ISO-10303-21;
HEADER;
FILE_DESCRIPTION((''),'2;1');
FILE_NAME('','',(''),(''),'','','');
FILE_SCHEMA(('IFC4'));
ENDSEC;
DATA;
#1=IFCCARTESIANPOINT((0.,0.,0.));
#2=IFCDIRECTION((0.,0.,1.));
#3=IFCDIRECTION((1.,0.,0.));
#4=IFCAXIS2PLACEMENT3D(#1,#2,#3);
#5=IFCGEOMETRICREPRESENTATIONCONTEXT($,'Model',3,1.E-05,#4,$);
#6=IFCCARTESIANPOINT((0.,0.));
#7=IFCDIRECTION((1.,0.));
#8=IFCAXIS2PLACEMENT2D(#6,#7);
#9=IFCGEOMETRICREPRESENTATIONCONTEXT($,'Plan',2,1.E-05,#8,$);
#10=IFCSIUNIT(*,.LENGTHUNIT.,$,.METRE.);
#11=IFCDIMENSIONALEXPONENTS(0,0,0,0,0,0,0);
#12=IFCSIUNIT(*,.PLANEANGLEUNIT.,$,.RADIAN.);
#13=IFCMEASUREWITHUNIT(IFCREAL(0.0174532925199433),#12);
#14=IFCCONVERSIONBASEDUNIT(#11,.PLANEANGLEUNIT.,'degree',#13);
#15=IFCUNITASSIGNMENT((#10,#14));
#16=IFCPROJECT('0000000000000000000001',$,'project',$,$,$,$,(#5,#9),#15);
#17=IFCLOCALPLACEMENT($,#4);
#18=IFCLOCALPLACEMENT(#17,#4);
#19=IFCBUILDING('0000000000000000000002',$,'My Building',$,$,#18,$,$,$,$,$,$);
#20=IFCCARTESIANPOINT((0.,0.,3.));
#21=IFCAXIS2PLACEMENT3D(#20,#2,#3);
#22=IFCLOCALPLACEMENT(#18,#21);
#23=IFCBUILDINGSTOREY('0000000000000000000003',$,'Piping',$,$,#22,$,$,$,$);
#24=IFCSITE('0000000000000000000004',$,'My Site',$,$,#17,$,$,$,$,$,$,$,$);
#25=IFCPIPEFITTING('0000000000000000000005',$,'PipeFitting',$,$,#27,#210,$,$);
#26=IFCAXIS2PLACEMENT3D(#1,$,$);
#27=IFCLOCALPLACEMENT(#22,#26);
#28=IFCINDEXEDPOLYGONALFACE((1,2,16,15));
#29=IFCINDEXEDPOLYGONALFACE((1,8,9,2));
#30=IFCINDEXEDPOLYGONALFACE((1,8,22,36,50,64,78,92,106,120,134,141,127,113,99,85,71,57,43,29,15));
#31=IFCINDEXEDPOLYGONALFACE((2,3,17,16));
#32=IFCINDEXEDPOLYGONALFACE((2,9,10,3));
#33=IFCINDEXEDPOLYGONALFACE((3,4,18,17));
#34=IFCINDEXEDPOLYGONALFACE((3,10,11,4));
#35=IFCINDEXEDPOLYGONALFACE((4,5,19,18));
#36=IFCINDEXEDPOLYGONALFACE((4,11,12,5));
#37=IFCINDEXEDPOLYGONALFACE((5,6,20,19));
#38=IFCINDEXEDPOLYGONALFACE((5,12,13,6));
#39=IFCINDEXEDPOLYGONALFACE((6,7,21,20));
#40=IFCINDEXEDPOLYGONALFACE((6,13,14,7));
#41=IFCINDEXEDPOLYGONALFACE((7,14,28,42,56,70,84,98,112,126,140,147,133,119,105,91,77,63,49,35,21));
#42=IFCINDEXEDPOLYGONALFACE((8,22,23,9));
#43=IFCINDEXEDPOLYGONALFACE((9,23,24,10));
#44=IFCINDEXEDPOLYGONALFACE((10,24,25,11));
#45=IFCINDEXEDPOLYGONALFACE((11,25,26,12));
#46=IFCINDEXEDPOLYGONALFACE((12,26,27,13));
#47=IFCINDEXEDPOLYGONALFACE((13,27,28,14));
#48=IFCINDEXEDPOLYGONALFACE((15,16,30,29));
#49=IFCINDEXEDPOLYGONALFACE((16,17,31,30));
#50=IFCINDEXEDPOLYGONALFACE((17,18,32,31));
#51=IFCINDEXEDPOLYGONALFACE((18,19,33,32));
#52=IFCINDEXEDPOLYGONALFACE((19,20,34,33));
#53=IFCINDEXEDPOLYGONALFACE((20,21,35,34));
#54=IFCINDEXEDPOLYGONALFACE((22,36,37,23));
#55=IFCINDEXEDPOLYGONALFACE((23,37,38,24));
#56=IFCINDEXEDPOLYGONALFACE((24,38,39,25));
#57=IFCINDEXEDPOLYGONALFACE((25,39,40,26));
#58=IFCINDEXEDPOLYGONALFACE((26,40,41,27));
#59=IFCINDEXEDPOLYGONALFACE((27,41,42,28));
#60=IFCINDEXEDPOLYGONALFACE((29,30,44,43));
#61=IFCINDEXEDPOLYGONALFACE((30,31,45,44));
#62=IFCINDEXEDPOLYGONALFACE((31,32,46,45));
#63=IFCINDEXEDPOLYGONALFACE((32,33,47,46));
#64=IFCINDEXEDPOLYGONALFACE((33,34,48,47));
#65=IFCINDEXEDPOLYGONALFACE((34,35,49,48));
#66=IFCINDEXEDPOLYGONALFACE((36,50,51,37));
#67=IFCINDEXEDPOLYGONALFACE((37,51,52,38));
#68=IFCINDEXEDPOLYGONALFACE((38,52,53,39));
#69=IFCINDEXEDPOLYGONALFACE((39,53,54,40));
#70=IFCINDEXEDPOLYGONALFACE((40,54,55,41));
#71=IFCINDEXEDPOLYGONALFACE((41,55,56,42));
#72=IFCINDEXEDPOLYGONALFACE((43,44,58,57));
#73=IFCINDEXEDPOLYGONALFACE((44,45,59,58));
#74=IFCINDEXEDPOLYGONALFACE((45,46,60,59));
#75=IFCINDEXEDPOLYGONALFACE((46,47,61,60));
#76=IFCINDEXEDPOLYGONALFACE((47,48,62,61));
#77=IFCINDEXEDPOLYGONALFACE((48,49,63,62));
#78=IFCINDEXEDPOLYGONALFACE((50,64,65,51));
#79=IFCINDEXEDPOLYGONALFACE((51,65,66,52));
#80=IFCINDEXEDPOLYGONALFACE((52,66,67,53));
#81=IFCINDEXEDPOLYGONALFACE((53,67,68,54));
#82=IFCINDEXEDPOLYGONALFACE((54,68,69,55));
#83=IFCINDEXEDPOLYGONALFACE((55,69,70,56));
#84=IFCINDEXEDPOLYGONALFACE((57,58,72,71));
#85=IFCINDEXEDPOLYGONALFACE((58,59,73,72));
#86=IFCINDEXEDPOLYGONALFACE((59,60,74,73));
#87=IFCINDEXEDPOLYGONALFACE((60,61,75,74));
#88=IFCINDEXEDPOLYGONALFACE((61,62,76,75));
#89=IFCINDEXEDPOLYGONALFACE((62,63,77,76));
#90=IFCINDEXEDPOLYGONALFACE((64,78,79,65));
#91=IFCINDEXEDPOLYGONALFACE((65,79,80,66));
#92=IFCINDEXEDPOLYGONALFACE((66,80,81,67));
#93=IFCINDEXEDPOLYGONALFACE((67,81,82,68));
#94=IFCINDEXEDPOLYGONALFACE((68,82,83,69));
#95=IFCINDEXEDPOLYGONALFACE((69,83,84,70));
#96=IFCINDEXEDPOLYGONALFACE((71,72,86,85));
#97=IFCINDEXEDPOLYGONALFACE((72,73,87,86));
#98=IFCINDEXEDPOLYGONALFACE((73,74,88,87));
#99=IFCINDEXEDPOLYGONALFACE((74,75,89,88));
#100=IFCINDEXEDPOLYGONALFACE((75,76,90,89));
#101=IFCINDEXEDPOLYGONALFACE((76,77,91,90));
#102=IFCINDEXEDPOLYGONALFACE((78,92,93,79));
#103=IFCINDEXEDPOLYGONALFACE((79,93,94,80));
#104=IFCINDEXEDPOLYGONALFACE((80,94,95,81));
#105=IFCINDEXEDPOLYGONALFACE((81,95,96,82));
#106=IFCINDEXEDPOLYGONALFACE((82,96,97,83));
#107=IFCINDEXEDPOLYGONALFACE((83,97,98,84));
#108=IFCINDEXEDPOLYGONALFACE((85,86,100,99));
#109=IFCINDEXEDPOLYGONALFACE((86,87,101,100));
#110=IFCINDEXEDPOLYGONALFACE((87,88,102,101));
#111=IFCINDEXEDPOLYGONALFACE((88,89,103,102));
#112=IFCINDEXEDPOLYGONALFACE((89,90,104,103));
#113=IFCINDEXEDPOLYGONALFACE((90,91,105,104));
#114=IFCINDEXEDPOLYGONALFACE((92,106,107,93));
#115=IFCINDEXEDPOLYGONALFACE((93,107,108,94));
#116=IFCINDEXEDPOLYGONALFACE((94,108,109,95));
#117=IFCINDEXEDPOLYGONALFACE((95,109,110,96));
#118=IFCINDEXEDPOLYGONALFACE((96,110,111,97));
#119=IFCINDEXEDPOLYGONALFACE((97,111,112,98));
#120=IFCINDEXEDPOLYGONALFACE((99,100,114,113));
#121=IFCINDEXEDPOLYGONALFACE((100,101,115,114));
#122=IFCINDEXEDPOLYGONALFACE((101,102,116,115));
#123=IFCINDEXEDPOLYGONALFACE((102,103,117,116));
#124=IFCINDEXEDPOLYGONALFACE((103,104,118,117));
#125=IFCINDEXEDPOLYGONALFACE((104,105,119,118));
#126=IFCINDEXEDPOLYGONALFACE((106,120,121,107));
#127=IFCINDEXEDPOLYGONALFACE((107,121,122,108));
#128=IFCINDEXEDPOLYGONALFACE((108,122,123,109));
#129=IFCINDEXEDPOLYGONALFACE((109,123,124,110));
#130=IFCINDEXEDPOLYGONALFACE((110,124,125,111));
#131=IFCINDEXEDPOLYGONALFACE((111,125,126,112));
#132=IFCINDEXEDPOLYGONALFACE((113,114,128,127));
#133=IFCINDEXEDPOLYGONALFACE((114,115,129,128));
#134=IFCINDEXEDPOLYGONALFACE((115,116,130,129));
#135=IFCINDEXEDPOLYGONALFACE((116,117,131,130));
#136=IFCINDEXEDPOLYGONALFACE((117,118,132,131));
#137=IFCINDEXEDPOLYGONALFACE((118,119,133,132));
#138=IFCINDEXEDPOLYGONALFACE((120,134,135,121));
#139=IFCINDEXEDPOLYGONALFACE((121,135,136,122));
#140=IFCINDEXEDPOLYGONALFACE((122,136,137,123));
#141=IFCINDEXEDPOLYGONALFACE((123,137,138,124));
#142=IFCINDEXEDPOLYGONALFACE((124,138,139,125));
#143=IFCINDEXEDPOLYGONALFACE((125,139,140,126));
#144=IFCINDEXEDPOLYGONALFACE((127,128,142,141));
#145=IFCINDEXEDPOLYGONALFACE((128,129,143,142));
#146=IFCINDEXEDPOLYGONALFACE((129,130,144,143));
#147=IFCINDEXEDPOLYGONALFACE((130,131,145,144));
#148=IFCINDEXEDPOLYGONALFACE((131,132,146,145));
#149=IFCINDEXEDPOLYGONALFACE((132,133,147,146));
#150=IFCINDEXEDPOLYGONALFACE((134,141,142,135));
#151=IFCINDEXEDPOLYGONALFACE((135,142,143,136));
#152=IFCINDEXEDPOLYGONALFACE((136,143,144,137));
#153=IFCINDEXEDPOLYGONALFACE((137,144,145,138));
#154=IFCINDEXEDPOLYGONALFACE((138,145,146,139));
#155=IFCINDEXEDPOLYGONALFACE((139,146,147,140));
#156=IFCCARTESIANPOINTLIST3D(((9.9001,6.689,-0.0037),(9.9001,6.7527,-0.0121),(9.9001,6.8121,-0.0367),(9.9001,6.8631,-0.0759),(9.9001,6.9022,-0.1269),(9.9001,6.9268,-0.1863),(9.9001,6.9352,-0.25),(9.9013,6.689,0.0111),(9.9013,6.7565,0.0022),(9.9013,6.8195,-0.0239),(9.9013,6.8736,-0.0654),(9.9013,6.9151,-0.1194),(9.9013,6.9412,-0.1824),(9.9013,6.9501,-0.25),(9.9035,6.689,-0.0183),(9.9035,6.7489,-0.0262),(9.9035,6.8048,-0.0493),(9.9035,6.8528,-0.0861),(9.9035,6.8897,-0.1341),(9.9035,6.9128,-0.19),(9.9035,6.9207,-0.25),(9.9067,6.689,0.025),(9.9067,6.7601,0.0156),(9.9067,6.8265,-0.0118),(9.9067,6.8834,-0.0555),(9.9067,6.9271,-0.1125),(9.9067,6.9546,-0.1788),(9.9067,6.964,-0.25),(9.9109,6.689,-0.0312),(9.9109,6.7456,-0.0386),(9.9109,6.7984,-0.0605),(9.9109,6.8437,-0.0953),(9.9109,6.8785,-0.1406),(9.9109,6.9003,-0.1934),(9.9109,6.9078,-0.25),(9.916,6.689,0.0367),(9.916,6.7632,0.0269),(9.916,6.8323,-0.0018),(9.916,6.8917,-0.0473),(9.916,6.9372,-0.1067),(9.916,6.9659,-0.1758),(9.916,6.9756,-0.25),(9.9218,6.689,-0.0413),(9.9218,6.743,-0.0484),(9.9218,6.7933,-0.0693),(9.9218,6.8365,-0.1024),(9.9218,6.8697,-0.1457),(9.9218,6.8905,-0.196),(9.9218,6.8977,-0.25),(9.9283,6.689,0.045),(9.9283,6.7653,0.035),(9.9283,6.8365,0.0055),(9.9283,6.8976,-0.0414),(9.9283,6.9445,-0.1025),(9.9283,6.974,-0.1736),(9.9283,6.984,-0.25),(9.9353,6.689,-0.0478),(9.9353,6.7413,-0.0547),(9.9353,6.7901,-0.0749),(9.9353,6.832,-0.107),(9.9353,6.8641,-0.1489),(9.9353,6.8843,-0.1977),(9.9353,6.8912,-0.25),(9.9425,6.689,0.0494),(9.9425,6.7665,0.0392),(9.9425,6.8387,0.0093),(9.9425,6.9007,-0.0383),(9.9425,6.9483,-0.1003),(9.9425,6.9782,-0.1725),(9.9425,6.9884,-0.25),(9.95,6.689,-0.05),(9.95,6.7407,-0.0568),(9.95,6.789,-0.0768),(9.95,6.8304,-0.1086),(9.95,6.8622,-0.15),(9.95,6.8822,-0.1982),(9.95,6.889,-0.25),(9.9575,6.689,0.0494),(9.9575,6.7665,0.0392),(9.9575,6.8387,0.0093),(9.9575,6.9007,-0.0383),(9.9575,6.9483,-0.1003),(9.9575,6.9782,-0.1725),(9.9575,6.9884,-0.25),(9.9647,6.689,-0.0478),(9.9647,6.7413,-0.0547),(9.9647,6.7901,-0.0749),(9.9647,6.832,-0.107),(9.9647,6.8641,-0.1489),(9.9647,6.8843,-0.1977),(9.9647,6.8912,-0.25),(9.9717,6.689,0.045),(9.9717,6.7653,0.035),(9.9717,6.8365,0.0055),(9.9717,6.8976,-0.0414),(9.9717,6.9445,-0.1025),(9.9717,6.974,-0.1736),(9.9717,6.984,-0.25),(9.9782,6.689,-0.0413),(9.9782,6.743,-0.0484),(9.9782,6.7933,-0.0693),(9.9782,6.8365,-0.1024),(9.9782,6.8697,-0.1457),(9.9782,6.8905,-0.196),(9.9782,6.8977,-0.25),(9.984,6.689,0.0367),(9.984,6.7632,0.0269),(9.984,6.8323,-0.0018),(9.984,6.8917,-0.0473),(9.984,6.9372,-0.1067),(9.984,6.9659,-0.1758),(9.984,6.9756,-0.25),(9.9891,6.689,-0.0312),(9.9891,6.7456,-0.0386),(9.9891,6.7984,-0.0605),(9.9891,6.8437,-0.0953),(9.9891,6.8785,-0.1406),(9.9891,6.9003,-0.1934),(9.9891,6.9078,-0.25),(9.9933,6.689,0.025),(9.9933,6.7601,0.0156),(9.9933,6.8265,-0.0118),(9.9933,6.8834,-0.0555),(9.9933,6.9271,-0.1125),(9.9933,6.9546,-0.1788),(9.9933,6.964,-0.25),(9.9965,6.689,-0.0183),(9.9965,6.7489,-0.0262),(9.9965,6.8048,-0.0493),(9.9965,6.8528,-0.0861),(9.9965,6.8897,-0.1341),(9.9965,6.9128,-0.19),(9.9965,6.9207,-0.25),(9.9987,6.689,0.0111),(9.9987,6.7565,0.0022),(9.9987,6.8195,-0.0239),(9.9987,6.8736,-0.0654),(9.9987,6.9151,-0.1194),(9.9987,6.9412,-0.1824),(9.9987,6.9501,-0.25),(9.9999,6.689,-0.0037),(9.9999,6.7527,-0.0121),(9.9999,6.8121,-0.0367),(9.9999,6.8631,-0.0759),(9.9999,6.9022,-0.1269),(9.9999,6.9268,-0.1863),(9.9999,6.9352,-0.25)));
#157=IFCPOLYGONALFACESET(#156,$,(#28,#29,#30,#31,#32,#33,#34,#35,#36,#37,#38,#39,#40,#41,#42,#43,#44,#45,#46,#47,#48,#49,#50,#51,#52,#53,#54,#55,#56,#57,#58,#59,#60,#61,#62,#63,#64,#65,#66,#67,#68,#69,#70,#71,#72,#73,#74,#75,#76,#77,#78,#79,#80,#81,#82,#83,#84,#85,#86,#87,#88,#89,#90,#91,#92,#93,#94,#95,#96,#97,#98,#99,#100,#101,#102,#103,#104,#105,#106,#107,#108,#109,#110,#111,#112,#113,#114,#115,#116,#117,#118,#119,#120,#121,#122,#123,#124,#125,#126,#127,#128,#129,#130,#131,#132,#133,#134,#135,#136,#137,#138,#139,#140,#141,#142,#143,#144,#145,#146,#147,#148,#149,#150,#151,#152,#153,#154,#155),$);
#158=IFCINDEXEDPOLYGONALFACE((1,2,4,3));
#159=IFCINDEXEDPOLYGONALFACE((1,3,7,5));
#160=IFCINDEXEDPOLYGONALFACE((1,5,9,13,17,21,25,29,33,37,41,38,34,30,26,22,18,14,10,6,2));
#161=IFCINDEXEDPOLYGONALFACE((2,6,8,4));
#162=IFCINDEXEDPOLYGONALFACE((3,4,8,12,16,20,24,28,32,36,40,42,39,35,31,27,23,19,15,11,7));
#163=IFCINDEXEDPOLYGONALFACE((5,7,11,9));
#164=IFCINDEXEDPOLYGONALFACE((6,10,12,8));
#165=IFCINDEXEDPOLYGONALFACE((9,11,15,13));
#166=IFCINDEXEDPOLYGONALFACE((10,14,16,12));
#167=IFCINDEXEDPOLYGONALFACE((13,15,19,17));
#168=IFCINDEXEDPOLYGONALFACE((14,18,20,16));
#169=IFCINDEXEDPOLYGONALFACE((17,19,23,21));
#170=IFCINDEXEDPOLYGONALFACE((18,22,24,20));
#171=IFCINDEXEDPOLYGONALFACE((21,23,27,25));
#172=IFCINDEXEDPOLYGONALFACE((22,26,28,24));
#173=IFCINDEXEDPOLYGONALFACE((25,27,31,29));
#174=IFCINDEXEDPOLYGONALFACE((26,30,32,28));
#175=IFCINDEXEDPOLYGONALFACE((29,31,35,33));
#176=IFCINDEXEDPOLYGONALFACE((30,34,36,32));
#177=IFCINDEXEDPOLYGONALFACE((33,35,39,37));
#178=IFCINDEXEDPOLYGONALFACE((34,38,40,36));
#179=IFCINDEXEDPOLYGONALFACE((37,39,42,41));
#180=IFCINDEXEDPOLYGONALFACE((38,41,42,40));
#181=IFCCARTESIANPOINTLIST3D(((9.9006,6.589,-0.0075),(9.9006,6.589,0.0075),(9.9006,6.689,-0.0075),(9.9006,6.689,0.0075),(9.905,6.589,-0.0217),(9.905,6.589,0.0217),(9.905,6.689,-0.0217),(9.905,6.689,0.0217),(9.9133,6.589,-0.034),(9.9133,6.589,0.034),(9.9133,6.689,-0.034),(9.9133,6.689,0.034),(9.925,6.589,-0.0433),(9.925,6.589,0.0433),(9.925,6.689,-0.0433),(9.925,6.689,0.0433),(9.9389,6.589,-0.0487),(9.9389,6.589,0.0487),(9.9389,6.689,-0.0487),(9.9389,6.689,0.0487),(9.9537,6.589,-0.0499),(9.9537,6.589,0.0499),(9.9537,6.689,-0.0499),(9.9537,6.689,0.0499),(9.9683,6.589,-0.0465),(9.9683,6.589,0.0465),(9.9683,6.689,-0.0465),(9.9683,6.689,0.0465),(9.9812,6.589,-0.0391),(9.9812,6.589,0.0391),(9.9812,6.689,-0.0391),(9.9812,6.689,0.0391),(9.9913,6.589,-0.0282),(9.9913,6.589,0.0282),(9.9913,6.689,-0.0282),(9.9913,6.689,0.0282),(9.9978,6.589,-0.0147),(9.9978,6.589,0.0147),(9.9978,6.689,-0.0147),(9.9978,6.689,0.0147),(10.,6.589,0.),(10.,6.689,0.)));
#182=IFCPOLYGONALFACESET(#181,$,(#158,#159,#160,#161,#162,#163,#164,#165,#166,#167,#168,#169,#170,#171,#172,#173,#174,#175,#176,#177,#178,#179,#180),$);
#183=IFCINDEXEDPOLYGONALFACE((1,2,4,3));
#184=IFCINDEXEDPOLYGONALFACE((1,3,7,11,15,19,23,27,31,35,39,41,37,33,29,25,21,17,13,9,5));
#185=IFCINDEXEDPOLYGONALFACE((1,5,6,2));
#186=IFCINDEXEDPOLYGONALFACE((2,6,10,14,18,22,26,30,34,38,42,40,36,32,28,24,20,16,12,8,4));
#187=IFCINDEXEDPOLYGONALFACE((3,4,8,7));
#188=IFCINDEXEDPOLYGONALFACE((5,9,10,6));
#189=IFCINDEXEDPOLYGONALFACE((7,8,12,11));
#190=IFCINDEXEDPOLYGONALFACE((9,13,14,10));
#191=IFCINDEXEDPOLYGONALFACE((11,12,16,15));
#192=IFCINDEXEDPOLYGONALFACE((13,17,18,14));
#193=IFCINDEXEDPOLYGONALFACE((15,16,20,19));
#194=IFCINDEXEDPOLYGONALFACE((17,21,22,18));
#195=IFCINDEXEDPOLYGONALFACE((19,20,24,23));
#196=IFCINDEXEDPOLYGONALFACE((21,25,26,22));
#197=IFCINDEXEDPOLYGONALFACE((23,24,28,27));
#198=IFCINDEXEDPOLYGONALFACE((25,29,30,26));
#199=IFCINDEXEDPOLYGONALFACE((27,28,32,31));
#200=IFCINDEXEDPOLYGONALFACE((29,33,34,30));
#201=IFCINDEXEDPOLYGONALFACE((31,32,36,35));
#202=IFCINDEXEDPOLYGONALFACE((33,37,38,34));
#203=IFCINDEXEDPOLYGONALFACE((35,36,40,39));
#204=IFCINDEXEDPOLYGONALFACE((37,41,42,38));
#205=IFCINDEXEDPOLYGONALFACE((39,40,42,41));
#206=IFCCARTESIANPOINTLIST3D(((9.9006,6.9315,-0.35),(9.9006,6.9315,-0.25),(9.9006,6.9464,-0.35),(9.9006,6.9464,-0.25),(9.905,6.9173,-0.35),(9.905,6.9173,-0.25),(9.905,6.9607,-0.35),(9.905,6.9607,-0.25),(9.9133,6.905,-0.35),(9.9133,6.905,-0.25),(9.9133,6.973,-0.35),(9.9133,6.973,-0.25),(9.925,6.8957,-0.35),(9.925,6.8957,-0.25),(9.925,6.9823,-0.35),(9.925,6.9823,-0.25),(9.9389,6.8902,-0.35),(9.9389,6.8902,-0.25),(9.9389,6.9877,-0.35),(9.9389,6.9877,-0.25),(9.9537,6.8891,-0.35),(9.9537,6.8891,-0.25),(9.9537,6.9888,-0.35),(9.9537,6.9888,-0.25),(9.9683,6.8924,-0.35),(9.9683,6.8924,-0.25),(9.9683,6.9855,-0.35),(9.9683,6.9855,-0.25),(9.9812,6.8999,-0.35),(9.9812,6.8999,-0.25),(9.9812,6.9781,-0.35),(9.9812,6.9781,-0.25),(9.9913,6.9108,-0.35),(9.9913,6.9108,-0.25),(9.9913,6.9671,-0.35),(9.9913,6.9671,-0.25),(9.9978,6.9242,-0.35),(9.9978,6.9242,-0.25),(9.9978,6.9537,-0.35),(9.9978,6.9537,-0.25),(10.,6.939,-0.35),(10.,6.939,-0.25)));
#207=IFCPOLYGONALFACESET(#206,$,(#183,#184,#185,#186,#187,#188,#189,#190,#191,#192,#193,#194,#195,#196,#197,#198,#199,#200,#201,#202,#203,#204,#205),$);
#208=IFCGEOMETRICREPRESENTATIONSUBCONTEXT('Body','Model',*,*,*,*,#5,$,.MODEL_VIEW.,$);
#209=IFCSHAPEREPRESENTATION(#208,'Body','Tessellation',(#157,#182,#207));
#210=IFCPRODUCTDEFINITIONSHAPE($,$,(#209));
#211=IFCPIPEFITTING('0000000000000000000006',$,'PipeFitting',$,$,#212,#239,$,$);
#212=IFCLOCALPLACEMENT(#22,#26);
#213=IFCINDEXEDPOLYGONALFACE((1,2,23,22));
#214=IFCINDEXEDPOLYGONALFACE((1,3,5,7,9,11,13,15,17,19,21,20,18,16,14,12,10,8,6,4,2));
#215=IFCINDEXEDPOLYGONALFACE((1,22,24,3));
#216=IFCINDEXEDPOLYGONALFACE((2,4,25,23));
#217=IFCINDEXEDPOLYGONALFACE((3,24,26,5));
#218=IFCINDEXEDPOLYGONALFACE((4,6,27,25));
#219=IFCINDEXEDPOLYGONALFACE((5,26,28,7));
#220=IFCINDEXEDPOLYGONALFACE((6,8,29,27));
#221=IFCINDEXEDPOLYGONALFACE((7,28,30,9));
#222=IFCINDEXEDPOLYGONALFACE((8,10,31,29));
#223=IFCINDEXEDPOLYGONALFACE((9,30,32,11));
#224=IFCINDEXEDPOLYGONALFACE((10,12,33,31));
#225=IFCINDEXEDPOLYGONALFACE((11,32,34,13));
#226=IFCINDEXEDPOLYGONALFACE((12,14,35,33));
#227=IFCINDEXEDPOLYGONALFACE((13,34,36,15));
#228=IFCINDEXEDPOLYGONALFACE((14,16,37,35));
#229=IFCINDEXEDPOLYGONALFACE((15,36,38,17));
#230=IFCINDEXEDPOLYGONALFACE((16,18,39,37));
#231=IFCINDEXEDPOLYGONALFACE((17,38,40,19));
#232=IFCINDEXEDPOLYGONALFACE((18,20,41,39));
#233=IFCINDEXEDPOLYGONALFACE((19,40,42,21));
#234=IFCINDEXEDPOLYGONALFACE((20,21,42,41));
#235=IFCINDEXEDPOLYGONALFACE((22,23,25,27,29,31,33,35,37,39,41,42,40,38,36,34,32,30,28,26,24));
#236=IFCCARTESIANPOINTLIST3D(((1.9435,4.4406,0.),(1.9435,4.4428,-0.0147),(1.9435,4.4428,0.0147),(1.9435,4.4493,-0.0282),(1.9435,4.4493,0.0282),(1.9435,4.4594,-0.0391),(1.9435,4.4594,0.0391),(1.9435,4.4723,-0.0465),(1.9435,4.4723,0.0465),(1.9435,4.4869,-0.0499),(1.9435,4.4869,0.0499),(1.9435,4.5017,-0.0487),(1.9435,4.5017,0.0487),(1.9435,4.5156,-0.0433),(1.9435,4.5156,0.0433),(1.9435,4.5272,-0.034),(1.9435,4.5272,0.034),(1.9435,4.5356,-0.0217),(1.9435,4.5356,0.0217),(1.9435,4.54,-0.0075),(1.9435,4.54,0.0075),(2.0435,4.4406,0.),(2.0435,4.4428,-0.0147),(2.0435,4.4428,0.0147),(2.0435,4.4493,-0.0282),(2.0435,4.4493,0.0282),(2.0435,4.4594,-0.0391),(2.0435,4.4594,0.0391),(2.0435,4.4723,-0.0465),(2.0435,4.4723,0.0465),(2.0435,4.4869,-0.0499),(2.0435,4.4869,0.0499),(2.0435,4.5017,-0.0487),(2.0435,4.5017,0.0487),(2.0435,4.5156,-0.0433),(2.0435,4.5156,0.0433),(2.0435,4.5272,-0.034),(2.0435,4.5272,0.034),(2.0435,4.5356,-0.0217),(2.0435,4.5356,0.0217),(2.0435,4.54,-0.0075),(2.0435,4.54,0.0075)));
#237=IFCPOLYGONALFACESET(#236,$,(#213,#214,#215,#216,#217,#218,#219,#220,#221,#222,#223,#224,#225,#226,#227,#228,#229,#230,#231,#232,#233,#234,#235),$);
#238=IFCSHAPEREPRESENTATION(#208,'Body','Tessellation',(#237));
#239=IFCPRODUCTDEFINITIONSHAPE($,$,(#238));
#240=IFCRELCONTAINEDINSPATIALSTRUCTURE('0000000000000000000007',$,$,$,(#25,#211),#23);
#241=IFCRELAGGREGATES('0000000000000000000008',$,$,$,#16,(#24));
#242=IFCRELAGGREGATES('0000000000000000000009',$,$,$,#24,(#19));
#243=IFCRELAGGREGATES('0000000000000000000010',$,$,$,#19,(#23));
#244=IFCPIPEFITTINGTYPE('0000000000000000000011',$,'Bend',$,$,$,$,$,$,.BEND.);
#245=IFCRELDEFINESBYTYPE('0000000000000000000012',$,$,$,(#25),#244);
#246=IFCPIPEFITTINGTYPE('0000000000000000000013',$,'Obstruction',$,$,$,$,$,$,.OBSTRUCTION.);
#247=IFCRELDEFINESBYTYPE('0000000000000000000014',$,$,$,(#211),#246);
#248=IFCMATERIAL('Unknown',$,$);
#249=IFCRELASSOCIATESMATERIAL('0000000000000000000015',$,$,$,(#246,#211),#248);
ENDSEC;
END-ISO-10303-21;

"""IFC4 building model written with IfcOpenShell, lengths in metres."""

from ifc_helpers import new_model, entity, si_unit, converted_unit, frame, origin_with_axes, origin_2d_with_axis, place, context, subcontext, project, spatial, circle, extrude, source, transform, mapped, material, material_profile, profile_set, profile_usage, type_object, type_shapes, element, save


model = new_model("IFC4")

# Units and contexts
model_context = context("Model", 3, precision=1e-05, world=origin_with_axes())
plan_context = context("Plan", 2, precision=1e-05, world=origin_2d_with_axis())
body_context = subcontext(model_context, "Body", "Model", "MODEL_VIEW")
ifc_project = project(units=[si_unit("LENGTHUNIT", "METRE"), converted_unit("PLANEANGLEUNIT", "degree", entity("IfcReal", 0.0174532925199433), si_unit("PLANEANGLEUNIT", "RADIAN"), dimensions=[0, 0, 0, 0, 0, 0, 0])], contexts=[model_context, plan_context])

# Site, building, storey
site_placement = place(None, origin_with_axes())
site = spatial("IfcSite", under=ifc_project, at=site_placement, Name="My Site")
building_placement = place(site_placement, origin_with_axes())
building = spatial("IfcBuilding", under=site, at=building_placement, Name="My Building")
storey_placement = place(building_placement, frame((0.0, 0.0, 3.0), z_axis=(0.0, 0.0, 1.0), x_axis=(1.0, 0.0, 0.0)))
storey = spatial("IfcBuildingStorey", under=building, at=storey_placement, Name="Piping")

# Shared definitions
ifc_material = material(Name="Unknown")

# Pipe fittings
pipe_fitting_type_1 = type_object("IfcPipeFittingType", Name="Bend", PredefinedType="BEND")
shared_shape = source(origin_with_axes(), body_context, "Body", "SolidModel", [
    entity("IfcSweptDiskSolid", entity("IfcIndexedPolyCurve", entity("IfcCartesianPointList3D", [[0.0, 0.0, -0.1], [0.0, -0.0732, -0.2768], [0.0, -0.25, -0.35]]), [entity("IfcArcIndex", [1, 2, 3])]), 0.05),
    extrude(circle(Radius=0.05), origin_with_axes(), (0.0, 0.0, -1.0), 0.1),
    extrude(circle(Radius=0.05), frame((0.0, -0.25, -0.35), z_axis=(0.0, -1.0, 0.0), x_axis=(1.0, 0.0, 0.0)), (0.0, 0.0, 1.0), 0.1),
])
type_shapes(pipe_fitting_type_1, [shared_shape])
for number, where, z_axis, x_axis, name in (
    (1, (9.95, 6.589, 0.0), (0.0, -1.0, 0.0), (1.0, 0.0, 0.0), "PipeFitting"),
):
    element("IfcPipeFitting", number, at=place(storey_placement, frame(where, z_axis=z_axis, x_axis=x_axis)), inside=storey, type_object=pipe_fitting_type_1, Name=name, context=body_context, shape_type="MappedRepresentation", body=[
        mapped(shared_shape, transform((0.0, 0.0, 0.0), x_axis=(1.0, 0.0, 0.0), y_axis=(0.0, 1.0, 0.0), z_axis=(0.0, 0.0, 1.0), scale=1.0)),
    ])
ifc_material_profile_1 = material_profile(ifc_material, circle(Radius=0.05))
ifc_profile_set_1 = profile_set([ifc_material_profile_1])
ifc_profile_usage_1 = profile_usage(ifc_profile_set_1, cardinal=5)
pipe_fitting_type_2 = type_object("IfcPipeFittingType", Name="Obstruction", PredefinedType="OBSTRUCTION", material=ifc_profile_set_1)
pipe_fitting_1_placement = place(storey_placement, frame((2.0435, 4.4906, 0.0), z_axis=(-1.0, 0.0, 0.0), x_axis=(0.0, -1.0, 0.0)))
element("IfcPipeFitting", 2, at=pipe_fitting_1_placement, inside=storey, type_object=pipe_fitting_type_2, material=ifc_profile_usage_1, Name="PipeFitting", context=body_context, shape_type="SweptSolid", body=[
    extrude(circle(Radius=0.05), origin_with_axes(), (0.0, 0.0, 1.0), 0.1),
])

save(model, "model.ifc")
